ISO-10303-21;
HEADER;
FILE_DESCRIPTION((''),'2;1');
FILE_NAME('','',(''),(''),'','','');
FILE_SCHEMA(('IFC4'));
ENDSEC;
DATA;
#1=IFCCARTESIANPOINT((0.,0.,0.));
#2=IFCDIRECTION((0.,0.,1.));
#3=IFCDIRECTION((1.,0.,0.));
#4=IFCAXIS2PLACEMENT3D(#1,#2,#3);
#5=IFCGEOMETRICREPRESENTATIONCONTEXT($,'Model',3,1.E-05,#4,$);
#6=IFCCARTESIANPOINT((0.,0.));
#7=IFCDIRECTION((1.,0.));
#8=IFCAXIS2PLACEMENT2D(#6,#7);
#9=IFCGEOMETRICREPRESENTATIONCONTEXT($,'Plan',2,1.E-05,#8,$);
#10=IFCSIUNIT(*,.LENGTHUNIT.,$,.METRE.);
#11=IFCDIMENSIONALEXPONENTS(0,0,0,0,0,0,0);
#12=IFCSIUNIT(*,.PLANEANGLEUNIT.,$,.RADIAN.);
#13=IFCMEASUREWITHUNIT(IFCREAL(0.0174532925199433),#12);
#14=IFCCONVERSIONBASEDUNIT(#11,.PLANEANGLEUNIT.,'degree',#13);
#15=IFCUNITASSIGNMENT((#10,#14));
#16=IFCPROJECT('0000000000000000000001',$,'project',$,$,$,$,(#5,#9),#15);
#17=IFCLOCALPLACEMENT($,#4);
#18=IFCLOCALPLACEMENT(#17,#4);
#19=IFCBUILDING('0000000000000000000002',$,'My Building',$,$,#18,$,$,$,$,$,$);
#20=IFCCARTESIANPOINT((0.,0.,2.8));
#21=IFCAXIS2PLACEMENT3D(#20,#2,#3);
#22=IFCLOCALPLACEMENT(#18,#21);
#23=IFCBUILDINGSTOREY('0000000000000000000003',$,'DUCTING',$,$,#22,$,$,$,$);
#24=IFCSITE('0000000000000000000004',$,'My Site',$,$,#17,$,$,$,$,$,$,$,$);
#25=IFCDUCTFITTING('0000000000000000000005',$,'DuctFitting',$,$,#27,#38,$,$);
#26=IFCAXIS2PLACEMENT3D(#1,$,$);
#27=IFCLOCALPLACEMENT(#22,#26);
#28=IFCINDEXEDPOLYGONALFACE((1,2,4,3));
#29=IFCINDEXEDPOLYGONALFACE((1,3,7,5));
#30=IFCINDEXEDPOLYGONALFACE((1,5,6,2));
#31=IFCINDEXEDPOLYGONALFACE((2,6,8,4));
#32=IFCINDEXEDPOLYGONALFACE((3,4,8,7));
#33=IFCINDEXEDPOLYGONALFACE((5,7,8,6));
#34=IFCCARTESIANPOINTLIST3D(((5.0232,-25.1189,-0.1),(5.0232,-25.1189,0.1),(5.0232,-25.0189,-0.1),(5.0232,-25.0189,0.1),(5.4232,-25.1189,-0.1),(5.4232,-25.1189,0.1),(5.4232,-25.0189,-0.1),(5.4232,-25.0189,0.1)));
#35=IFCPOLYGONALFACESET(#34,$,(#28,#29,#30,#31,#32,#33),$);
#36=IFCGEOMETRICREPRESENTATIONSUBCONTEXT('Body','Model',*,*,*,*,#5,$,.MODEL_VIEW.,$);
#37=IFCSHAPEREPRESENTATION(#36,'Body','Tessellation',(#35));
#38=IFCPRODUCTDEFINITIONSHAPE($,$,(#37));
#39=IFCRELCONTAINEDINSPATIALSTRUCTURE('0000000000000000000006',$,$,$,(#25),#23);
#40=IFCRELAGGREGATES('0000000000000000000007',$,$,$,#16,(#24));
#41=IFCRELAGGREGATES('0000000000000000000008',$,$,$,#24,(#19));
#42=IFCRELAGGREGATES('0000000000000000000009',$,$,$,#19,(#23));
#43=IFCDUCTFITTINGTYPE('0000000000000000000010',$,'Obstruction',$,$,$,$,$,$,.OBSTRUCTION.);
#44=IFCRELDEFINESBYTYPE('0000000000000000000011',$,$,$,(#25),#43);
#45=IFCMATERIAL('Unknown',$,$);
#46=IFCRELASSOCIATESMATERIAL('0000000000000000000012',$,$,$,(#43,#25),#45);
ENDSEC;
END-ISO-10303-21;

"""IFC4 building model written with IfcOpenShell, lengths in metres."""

from ifc_helpers import new_model, entity, si_unit, converted_unit, frame, origin_with_axes, origin_2d_with_axis, place, context, subcontext, project, spatial, rectangle, extrude, material, material_profile, profile_set, profile_usage, type_object, element, save


model = new_model("IFC4")

# Units and contexts
model_context = context("Model", 3, precision=1e-05, world=origin_with_axes())
plan_context = context("Plan", 2, precision=1e-05, world=origin_2d_with_axis())
body_context = subcontext(model_context, "Body", "Model", "MODEL_VIEW")
ifc_project = project(units=[si_unit("LENGTHUNIT", "METRE"), converted_unit("PLANEANGLEUNIT", "degree", entity("IfcReal", 0.0174532925199433), si_unit("PLANEANGLEUNIT", "RADIAN"), dimensions=[0, 0, 0, 0, 0, 0, 0])], contexts=[model_context, plan_context])

# Site, building, storey
site_placement = place(None, origin_with_axes())
site = spatial("IfcSite", under=ifc_project, at=site_placement, Name="My Site")
building_placement = place(site_placement, origin_with_axes())
building = spatial("IfcBuilding", under=site, at=building_placement, Name="My Building")
storey_placement = place(building_placement, frame((0.0, 0.0, 2.8), z_axis=(0.0, 0.0, 1.0), x_axis=(1.0, 0.0, 0.0)))
storey = spatial("IfcBuildingStorey", under=building, at=storey_placement, Name="DUCTING")

# Shared definitions
ifc_material = material(Name="Unknown")

# Duct fitting
ifc_material_profile_1 = material_profile(ifc_material, rectangle(XDim=0.4, YDim=0.2))
ifc_profile_set_1 = profile_set([ifc_material_profile_1])
duct_fitting_type_1 = type_object("IfcDuctFittingType", Name="Obstruction", PredefinedType="OBSTRUCTION", material=ifc_profile_set_1)
ifc_profile_usage_1 = profile_usage(ifc_profile_set_1, cardinal=5)
duct_fitting_1_placement = place(storey_placement, frame((5.2232, -25.0189, 0.0), z_axis=(0.0, -1.0, 0.0), x_axis=(1.0, 0.0, 0.0)))
element("IfcDuctFitting", 1, at=duct_fitting_1_placement, inside=storey, type_object=duct_fitting_type_1, material=ifc_profile_usage_1, Name="DuctFitting", context=body_context, shape_type="SweptSolid", body=[
    extrude(rectangle(XDim=0.4, YDim=0.2), origin_with_axes(), (0.0, 0.0, 1.0), 0.1),
])

save(model, "model.ifc")
